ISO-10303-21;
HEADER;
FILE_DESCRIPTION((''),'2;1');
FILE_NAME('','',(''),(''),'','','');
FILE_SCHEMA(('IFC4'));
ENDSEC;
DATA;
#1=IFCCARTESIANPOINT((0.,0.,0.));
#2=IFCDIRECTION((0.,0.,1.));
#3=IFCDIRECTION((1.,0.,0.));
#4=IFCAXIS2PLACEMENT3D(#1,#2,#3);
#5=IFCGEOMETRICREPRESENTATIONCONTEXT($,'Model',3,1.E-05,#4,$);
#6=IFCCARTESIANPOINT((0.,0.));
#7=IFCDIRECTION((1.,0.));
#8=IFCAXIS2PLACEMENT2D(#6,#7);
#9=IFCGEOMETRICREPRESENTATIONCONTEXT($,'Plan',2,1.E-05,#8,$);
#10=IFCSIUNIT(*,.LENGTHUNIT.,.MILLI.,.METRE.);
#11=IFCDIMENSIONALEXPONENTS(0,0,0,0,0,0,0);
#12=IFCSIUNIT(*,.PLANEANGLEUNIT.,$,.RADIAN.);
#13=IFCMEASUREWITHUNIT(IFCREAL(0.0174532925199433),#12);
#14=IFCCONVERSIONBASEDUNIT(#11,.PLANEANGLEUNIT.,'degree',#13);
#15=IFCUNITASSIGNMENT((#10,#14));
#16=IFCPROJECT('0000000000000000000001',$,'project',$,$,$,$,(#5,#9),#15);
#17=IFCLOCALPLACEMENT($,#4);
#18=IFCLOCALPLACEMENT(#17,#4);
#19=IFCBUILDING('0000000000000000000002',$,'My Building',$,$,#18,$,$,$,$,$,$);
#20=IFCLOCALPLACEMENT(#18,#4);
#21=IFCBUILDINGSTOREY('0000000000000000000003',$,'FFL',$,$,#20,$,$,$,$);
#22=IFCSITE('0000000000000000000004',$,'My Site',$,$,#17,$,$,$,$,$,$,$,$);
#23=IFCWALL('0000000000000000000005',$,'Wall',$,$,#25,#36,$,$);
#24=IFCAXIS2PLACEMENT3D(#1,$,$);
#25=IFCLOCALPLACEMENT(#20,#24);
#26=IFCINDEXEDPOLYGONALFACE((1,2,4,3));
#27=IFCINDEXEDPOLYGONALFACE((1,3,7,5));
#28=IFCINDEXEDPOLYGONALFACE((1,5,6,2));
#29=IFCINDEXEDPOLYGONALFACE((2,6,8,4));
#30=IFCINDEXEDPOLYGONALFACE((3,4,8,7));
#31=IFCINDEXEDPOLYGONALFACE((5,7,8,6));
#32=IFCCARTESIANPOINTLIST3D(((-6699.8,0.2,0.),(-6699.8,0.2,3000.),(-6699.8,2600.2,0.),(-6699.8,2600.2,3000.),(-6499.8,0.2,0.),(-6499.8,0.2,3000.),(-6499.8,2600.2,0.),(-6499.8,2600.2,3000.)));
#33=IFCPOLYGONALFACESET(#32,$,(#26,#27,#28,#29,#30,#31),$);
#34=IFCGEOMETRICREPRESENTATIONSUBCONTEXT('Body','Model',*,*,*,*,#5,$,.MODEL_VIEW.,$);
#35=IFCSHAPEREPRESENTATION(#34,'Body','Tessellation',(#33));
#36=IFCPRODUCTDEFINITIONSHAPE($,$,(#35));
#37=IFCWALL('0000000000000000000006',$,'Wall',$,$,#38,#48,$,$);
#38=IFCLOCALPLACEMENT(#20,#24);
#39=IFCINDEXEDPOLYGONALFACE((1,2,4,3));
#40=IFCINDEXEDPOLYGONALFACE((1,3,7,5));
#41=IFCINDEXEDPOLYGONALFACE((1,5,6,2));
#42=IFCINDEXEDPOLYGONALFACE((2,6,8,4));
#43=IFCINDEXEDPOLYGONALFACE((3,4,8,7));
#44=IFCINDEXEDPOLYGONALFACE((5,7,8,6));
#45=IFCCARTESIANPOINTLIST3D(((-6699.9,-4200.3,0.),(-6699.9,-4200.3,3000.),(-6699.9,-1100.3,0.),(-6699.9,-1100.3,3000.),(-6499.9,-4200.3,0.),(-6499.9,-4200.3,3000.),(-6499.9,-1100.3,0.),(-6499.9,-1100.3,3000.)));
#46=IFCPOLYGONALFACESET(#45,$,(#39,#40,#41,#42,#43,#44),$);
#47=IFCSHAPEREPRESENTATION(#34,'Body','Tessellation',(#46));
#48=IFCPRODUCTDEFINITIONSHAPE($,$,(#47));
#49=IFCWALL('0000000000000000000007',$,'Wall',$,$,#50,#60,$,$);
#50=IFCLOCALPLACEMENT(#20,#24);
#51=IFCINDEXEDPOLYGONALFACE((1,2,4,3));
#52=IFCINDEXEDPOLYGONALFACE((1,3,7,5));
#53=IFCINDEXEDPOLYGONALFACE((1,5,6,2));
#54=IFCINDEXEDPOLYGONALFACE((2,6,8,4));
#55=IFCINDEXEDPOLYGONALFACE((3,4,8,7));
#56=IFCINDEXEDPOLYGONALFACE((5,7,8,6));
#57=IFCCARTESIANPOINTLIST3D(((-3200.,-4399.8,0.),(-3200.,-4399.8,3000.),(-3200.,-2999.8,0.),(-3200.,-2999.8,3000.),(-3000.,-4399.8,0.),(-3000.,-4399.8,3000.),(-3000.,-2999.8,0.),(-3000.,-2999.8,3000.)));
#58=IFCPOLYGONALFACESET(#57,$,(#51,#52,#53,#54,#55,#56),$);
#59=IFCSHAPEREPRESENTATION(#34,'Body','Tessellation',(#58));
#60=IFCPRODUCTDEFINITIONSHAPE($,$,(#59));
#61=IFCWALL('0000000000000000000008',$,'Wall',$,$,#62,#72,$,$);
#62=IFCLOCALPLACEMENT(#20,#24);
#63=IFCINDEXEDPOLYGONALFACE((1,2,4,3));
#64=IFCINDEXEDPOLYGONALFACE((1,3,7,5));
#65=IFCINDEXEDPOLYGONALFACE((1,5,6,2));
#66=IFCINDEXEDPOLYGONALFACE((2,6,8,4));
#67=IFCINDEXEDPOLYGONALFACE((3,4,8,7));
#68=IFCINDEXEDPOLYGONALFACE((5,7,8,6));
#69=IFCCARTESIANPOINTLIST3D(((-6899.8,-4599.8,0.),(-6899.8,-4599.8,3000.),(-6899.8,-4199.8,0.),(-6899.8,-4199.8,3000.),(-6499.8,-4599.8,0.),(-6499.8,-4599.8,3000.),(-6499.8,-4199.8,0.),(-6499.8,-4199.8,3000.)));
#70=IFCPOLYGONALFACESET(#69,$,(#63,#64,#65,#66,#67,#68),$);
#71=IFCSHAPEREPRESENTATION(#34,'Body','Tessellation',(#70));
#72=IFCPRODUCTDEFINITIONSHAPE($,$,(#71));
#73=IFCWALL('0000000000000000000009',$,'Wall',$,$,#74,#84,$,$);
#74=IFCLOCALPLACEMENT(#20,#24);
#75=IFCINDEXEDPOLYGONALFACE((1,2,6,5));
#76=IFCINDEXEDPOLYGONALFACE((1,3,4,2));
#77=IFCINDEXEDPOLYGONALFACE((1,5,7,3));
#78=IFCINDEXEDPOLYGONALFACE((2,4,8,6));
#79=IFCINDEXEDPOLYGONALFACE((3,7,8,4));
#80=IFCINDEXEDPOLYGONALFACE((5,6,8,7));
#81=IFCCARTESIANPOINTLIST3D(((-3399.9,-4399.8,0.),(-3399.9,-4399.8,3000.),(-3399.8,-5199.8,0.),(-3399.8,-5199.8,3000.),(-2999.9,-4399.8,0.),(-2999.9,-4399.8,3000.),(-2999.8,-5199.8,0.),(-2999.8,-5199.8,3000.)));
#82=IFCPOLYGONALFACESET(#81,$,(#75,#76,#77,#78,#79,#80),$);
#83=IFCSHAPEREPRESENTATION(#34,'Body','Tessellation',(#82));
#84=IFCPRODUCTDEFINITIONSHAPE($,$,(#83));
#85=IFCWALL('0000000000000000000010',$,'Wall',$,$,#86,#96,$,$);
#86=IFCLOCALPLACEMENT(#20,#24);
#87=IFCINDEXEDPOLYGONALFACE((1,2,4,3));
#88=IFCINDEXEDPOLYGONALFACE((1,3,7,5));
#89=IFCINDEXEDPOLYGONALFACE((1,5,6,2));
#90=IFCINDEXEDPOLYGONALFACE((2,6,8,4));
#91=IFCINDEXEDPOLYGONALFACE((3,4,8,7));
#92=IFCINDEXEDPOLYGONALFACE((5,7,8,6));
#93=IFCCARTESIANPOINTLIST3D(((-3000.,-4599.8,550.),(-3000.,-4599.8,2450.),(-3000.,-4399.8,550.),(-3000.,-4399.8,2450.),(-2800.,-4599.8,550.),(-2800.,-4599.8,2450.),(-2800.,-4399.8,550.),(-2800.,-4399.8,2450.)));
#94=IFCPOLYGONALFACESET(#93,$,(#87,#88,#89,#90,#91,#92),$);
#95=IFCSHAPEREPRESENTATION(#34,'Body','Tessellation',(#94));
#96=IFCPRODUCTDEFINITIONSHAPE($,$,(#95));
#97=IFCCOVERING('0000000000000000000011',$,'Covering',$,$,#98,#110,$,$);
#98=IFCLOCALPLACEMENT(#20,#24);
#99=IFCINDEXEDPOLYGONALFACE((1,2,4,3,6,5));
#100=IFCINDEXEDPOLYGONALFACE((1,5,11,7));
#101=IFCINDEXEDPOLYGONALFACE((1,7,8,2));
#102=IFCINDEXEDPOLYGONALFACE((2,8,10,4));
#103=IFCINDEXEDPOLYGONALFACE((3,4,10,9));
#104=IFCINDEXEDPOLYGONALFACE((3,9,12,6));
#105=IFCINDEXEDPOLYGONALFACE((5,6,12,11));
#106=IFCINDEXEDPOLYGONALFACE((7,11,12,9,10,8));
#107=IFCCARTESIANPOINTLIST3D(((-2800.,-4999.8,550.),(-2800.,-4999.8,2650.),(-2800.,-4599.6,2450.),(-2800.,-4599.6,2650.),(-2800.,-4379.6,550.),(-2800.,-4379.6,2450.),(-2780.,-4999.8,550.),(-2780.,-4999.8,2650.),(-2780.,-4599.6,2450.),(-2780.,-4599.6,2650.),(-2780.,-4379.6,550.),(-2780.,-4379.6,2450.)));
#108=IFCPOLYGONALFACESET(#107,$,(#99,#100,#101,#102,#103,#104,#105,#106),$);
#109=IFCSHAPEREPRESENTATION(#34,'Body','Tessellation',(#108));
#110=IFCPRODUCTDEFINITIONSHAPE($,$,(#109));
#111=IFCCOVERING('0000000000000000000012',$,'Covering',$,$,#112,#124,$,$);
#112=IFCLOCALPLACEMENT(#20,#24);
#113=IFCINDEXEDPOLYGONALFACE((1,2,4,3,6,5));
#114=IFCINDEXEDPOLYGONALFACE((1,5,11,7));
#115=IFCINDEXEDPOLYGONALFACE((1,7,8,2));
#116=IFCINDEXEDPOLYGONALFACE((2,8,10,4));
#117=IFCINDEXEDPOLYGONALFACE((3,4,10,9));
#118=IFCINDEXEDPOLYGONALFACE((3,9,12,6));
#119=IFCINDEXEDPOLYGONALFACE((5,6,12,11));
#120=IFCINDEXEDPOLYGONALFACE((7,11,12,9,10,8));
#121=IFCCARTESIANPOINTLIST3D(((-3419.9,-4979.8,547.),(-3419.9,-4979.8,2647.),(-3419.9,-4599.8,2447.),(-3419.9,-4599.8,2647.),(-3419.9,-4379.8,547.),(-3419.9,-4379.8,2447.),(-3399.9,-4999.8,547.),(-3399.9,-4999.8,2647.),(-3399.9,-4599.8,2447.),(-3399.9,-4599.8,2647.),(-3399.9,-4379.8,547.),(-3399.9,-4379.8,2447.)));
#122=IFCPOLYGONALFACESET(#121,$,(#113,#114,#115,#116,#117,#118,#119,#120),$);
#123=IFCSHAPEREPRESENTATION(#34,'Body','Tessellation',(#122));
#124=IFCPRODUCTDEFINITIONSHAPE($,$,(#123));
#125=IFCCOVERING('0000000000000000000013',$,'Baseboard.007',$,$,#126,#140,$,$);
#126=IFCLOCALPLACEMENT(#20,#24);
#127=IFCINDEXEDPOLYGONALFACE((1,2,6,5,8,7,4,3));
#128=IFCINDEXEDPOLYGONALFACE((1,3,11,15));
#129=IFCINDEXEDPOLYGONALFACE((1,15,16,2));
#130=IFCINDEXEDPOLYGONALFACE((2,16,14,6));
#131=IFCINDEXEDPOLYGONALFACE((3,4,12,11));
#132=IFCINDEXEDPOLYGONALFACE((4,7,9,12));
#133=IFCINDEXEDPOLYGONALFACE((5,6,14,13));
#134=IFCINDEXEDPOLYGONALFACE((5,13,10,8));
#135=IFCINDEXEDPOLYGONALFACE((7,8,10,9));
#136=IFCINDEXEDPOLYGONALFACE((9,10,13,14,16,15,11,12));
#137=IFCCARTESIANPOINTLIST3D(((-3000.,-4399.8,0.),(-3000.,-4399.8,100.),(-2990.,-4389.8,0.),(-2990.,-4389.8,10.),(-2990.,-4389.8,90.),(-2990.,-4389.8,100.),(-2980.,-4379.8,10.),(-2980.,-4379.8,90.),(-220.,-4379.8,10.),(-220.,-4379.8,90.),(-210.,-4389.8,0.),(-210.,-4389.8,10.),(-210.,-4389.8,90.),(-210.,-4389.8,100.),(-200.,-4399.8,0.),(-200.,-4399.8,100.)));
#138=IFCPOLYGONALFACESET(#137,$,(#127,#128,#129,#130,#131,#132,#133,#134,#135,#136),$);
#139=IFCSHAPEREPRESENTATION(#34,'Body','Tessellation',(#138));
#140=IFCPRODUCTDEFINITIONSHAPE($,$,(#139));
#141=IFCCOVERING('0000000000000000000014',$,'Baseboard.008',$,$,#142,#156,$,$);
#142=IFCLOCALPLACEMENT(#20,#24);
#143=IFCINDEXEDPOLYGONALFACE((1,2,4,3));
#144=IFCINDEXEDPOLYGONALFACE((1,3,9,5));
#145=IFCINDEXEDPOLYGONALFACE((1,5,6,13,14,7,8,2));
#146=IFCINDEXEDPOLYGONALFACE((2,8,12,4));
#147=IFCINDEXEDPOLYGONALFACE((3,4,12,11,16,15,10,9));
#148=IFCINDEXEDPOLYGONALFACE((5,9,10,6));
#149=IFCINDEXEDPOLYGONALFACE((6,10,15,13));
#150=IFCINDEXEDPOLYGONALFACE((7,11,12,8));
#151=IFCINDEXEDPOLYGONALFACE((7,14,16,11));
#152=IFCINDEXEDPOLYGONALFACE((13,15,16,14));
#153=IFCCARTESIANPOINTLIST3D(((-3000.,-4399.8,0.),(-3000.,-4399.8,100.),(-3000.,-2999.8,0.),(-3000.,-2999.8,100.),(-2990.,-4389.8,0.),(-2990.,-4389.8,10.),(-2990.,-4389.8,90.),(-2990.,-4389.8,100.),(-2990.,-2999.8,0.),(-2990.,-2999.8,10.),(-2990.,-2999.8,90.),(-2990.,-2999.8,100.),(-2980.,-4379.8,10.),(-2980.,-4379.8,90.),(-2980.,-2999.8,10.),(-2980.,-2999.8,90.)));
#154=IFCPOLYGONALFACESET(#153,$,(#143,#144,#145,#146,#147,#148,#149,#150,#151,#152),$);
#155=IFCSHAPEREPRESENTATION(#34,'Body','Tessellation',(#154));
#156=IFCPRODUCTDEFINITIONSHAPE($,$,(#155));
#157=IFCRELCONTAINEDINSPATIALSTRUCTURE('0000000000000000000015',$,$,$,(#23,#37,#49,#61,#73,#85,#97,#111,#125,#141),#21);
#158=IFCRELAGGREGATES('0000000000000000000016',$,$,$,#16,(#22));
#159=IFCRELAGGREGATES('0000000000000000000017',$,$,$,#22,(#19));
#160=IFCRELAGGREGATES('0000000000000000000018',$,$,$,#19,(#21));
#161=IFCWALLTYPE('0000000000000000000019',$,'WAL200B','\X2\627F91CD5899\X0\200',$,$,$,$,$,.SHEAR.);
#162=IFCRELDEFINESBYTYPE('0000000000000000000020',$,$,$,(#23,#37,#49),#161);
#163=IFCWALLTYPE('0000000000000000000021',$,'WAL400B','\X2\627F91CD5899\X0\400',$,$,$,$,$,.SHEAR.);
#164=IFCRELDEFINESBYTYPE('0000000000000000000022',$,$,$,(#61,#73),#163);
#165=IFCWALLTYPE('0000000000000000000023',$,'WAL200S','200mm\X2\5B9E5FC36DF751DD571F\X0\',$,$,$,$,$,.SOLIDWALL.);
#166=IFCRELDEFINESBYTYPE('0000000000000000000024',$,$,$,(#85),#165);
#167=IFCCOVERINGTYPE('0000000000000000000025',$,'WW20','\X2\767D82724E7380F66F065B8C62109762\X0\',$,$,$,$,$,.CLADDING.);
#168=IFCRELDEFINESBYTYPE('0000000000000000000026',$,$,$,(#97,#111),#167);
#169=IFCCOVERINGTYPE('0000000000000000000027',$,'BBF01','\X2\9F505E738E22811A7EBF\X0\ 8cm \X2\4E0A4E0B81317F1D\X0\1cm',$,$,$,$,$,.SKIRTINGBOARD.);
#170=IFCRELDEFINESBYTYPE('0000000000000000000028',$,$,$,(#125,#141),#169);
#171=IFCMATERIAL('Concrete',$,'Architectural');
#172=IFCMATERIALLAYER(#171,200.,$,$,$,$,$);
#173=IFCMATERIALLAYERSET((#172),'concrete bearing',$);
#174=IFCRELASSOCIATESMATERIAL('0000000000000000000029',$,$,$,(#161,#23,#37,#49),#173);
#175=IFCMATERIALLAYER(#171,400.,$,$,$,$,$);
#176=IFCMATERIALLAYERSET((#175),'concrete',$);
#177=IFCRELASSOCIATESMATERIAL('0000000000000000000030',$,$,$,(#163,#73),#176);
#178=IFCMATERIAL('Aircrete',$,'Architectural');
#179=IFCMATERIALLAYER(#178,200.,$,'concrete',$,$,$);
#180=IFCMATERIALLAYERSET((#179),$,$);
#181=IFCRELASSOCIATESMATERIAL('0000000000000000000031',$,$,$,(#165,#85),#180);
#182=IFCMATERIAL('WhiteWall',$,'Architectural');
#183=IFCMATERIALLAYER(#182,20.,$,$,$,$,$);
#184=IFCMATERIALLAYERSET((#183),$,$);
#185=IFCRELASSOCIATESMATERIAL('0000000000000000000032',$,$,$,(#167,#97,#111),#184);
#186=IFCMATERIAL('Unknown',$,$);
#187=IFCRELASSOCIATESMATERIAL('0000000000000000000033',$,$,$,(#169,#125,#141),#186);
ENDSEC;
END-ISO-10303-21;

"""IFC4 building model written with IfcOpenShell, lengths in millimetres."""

from ifc_helpers import new_model, entity, si_unit, converted_unit, frame, origin_with_axes, origin_2d_with_axis, place, context, subcontext, project, spatial, line, indexed_curve, outline, extrude, clip, halfspace, material, layer, layer_set, layer_usage, material_profile, profile_set, profile_usage, type_object, element, save


model = new_model("IFC4")

# Units and contexts
model_context = context("Model", 3, precision=1e-05, world=origin_with_axes())
plan_context = context("Plan", 2, precision=1e-05, world=origin_2d_with_axis())
body_context_1 = subcontext(model_context, "Body", "Model", "MODEL_VIEW")
ifc_project = project(units=[si_unit("LENGTHUNIT", "METRE", prefix="MILLI"), converted_unit("PLANEANGLEUNIT", "degree", entity("IfcReal", 0.0174532925199433), si_unit("PLANEANGLEUNIT", "RADIAN"), dimensions=[0, 0, 0, 0, 0, 0, 0])], contexts=[model_context, plan_context])

# Site, building, storey
site_placement = place(None, origin_with_axes())
site = spatial("IfcSite", under=ifc_project, at=site_placement, Name="My Site")
building_placement = place(site_placement, origin_with_axes())
building = spatial("IfcBuilding", under=site, at=building_placement, Name="My Building")
storey_placement = place(building_placement, origin_with_axes())
storey = spatial("IfcBuildingStorey", under=building, at=storey_placement, Name="FFL")

# Shared definitions
ifc_material_1 = material(Name="Aircrete", Category="Architectural")

# Walls
ifc_material_2 = material(Name="Concrete", Category="Architectural")
ifc_layer_1 = layer(ifc_material_2, 200.0)
ifc_layer_set_1 = layer_set([ifc_layer_1], Name="concrete bearing")
ifc_layer_usage_1 = layer_usage(ifc_layer_set_1, "AXIS2", "NEGATIVE", 0.0)
wall_type_1 = type_object("IfcWallType", Name="WAL200B", Description="承重墙200", PredefinedType="SHEAR", material=ifc_layer_set_1)
wall_1_placement = place(storey_placement, frame((-6699.8, 0.2, 0.0), z_axis=(0.0, 0.0, 1.0), x_axis=(0.0, 1.0, 0.0)))
element("IfcWall", 1, at=wall_1_placement, inside=storey, type_object=wall_type_1, material=ifc_layer_usage_1, Name="Wall", context=body_context_1, shape_type="SweptSolid", body=[
    extrude(outline(indexed_curve([(0.0, -200.0), (0.0, 0.0), (2600.0, 0.0), (2600.0, -200.0)], segments=[line(1, 2, 3, 4, 1)])), origin_with_axes(), (0.0, 0.0, 1.0), 3000.0),
])
ifc_layer_usage_2 = layer_usage(ifc_layer_set_1, "AXIS2", "NEGATIVE", 0.0)
wall_2_placement = place(storey_placement, frame((-6499.9, -1100.3, 0.0), z_axis=(0.0, 0.0, 1.0), x_axis=(0.0, -1.0, 0.0)))
element("IfcWall", 2, at=wall_2_placement, inside=storey, type_object=wall_type_1, material=ifc_layer_usage_2, Name="Wall", context=body_context_1, shape_type="SweptSolid", body=[
    extrude(outline(indexed_curve([(0.0, -200.0), (0.0, 0.0), (3100.0, 0.0), (3100.0, -200.0)], segments=[line(1, 2, 3, 4, 1)])), origin_with_axes(), (0.0, 0.0, 1.0), 3000.0),
])
ifc_layer_usage_3 = layer_usage(ifc_layer_set_1, "AXIS2", "NEGATIVE", 0.0)
wall_3_placement = place(storey_placement, frame((-3200.0, -4399.8, 0.0), z_axis=(0.0, 0.0, 1.0), x_axis=(0.000007, 1.0, 0.0)))
element("IfcWall", 3, at=wall_3_placement, inside=storey, type_object=wall_type_1, material=ifc_layer_usage_3, Name="Wall", context=body_context_1, shape_type="SweptSolid", body=[
    extrude(outline(indexed_curve([(0.0, -200.0), (0.0, 0.0), (1400.0, 0.0), (1400.0, -200.0)], segments=[line(1, 2, 3, 4, 1)])), origin_with_axes(), (0.0, 0.0, 1.0), 3000.0),
])
ifc_layer_2 = layer(ifc_material_2, 400.0)
ifc_layer_set_2 = layer_set([ifc_layer_2], Name="concrete")
wall_type_2 = type_object("IfcWallType", Name="WAL400B", Description="承重墙400", PredefinedType="SHEAR", material=ifc_layer_set_2)
wall_4_placement = place(storey_placement, frame((-6499.8, -4599.8, 0.0), z_axis=(0.0, 0.0, 1.0), x_axis=(0.0, 1.0, 0.0)))
element("IfcWall", 4, at=wall_4_placement, inside=storey, type_object=wall_type_2, Name="Wall", context=body_context_1, shape_type="SweptSolid", body=[
    extrude(outline(indexed_curve([(0.0, 0.0), (0.0, 400.0), (400.0, 400.0), (400.0, 0.0), (0.0, 0.0)])), origin_with_axes(), (0.0, 0.0, 1.0), 3000.0),
])
ifc_layer_usage_4 = layer_usage(ifc_layer_set_2, "AXIS2", "POSITIVE", 0.0)
wall_5_placement = place(storey_placement, frame((-3399.9, -4399.8, 0.0), z_axis=(0.0, 0.0, 1.0), x_axis=(0.000114, -1.0, 0.0)))
element("IfcWall", 5, at=wall_5_placement, inside=storey, type_object=wall_type_2, material=ifc_layer_usage_4, Name="Wall", context=body_context_1, shape_type="SweptSolid", body=[
    extrude(outline(indexed_curve([(0.0, 0.0), (0.0, 400.0), (800.0, 400.0), (800.0, 0.0)], segments=[line(1, 2, 3, 4, 1)])), origin_with_axes(), (0.0, 0.0, 1.0), 3000.0),
])
ifc_layer_3 = layer(ifc_material_1, 200.0, Name="concrete")
ifc_layer_set_3 = layer_set([ifc_layer_3])
ifc_layer_usage_5 = layer_usage(ifc_layer_set_3, "AXIS2", "NEGATIVE", 0.0)
wall_type_3 = type_object("IfcWallType", Name="WAL200S", Description="200mm实心混凝土", PredefinedType="SOLIDWALL", material=ifc_layer_set_3)
wall_6_placement = place(storey_placement, frame((-2800.0, -4399.8, 550.0), z_axis=(0.0, 0.0, 1.0), x_axis=(0.000002, -1.0, 0.0)))
element("IfcWall", 6, at=wall_6_placement, inside=storey, type_object=wall_type_3, material=ifc_layer_usage_5, Name="Wall", context=body_context_1, shape_type="SweptSolid", body=[
    extrude(outline(indexed_curve([(0.0, -200.0), (0.0, 0.0), (200.0, 0.0), (200.0, -200.0)], segments=[line(1, 2, 3, 4, 1)])), origin_with_axes(), (0.0, 0.0, 1.0), 1900.0),
])

# Coverings, openings
ifc_material_3 = material(Name="WhiteWall", Category="Architectural")
ifc_layer_4 = layer(ifc_material_3, 20.0)
ifc_layer_set_4 = layer_set([ifc_layer_4])
ifc_layer_usage_6 = layer_usage(ifc_layer_set_4, "AXIS2", "NEGATIVE", 0.0)
covering_type_1 = type_object("IfcCoveringType", Name="WW20", Description="白色乳胶漆完成面", PredefinedType="CLADDING", material=ifc_layer_set_4)
covering_1_placement = place(storey_placement, frame((-2800.0, -4999.8, 550.0), z_axis=(0.0, 0.0, 1.0), x_axis=(0.000001, 1.0, 0.0)))
covering_1 = element("IfcCovering", 7, at=covering_1_placement, inside=storey, type_object=covering_type_1, material=ifc_layer_usage_6, Name="Covering", context=body_context_1, shape_type="SweptSolid", body=[
    extrude(outline(indexed_curve([(0.0, -20.0), (0.0, 0.0), (620.2, 0.0), (620.2, -20.0)], segments=[line(1, 2, 3, 4, 1)])), origin_with_axes(), (0.0, 0.0, 1.0), 2100.0),
])
opening_1_placement = place(covering_1_placement, frame((620.2, 120.0, 1900.0), z_axis=(0.000001, -1.0, 0.0), x_axis=(0.0, 0.0, 1.0)))
element("IfcOpeningElement", 8, at=opening_1_placement, cuts=covering_1, PredefinedType="OPENING", context=body_context_1, shape_type="SweptSolid", body=[
    extrude(outline(indexed_curve([(0.0, 220.0), (500.0, 220.0), (500.0, -100.0), (0.0, -100.0), (0.0, 220.0)])), origin_with_axes(), (0.0, 0.0, 1.0), 500.0),
])
ifc_layer_usage_7 = layer_usage(ifc_layer_set_4, "AXIS2", "POSITIVE", 0.0)
covering_2_placement = place(storey_placement, frame((-3399.9, -4999.8, 547.0), z_axis=(0.0, 0.0, 1.0), x_axis=(0.000002, 1.0, 0.0)))
covering_2 = element("IfcCovering", 9, at=covering_2_placement, inside=storey, type_object=covering_type_1, material=ifc_layer_usage_7, Name="Covering", context=body_context_1, shape_type="SweptSolid", body=[
    extrude(outline(indexed_curve([(0.0, 0.0), (20.0, 20.0), (620.0, 20.0), (620.0, 0.0)], segments=[line(1, 2, 3, 4, 1)])), origin_with_axes(), (0.0, 0.0, 1.0), 2100.0),
])
opening_2_placement = place(covering_2_placement, frame((620.0, 120.0, 1900.0), z_axis=(0.000001, -1.0, 0.0), x_axis=(0.0, 0.0, 1.0)))
element("IfcOpeningElement", 10, at=opening_2_placement, cuts=covering_2, PredefinedType="OPENING", context=body_context_1, shape_type="SweptSolid", body=[
    extrude(outline(indexed_curve([(0.0, 220.0), (500.0, 220.0), (500.0, -100.0), (0.0, -100.0), (0.0, 220.0)])), origin_with_axes(), (0.0, 0.0, 1.0), 500.0),
])

# Coverings
ifc_material_4 = material(Name="Unknown")
ifc_material_profile = material_profile(ifc_material_4, outline(indexed_curve([(0.0, 100.0), (10.0, 100.0), (10.0, 90.0), (20.0, 90.0), (20.0, 10.0), (10.0, 10.0), (10.0, 0.0), (0.0, 0.0), (0.0, 100.0)])))
ifc_profile_set = profile_set([ifc_material_profile])
ifc_profile_usage_1 = profile_usage(ifc_profile_set, cardinal=5)
covering_type_2 = type_object("IfcCoveringType", Name="BBF01", Description="齐平踢脚线 8cm 上下脱缝1cm", PredefinedType="SKIRTINGBOARD", material=ifc_profile_set)
covering_3_placement = place(storey_placement, frame((-3000.0, -4399.8, 0.0), z_axis=(1.0, 0.0, 0.0), x_axis=(0.0, 1.0, 0.0)))
element("IfcCovering", 11, at=covering_3_placement, inside=storey, type_object=covering_type_2, material=ifc_profile_usage_1, Name="Baseboard.007", context=body_context_1, shape_type="Clipping", body=[
    clip(clip(extrude(outline(indexed_curve([(0.0, 100.0), (10.0, 100.0), (10.0, 90.0), (20.0, 90.0), (20.0, 10.0), (10.0, 10.0), (10.0, 0.0), (0.0, 0.0), (0.0, 100.0)])), origin_with_axes(), (0.0, 0.0, 1.0), 2800.0), halfspace(frame((0.0, 0.0, 0.0), z_axis=(0.707106, 0.0, -0.707107), x_axis=(0.0, -1.0, 0.0)), False)), halfspace(frame((0.0, 0.0, 2800.0), z_axis=(0.707107, 0.0, 0.707106), x_axis=(0.0, -1.0, 0.0)), False)),
])
ifc_profile_usage_2 = profile_usage(ifc_profile_set, cardinal=5)
covering_4_placement = place(storey_placement, frame((-3000.0, -2999.8, 0.0), z_axis=(-0.000001, -1.0, 0.0), x_axis=(1.0, -0.000001, 0.0)))
element("IfcCovering", 12, at=covering_4_placement, inside=storey, type_object=covering_type_2, material=ifc_profile_usage_2, Name="Baseboard.008", context=body_context_1, shape_type="Clipping", body=[
    clip(extrude(outline(indexed_curve([(0.0, 100.0), (10.0, 100.0), (10.0, 90.0), (20.0, 90.0), (20.0, 10.0), (10.0, 10.0), (10.0, 0.0), (0.0, 0.0), (0.0, 100.0)])), origin_with_axes(), (0.0, 0.0, 1.0), 1400.0), halfspace(frame((0.0, 0.0, 1400.0), z_axis=(0.707107, 0.0, 0.707106), x_axis=(0.0, -1.0, 0.0)), False)),
])

save(model, "model.ifc")
